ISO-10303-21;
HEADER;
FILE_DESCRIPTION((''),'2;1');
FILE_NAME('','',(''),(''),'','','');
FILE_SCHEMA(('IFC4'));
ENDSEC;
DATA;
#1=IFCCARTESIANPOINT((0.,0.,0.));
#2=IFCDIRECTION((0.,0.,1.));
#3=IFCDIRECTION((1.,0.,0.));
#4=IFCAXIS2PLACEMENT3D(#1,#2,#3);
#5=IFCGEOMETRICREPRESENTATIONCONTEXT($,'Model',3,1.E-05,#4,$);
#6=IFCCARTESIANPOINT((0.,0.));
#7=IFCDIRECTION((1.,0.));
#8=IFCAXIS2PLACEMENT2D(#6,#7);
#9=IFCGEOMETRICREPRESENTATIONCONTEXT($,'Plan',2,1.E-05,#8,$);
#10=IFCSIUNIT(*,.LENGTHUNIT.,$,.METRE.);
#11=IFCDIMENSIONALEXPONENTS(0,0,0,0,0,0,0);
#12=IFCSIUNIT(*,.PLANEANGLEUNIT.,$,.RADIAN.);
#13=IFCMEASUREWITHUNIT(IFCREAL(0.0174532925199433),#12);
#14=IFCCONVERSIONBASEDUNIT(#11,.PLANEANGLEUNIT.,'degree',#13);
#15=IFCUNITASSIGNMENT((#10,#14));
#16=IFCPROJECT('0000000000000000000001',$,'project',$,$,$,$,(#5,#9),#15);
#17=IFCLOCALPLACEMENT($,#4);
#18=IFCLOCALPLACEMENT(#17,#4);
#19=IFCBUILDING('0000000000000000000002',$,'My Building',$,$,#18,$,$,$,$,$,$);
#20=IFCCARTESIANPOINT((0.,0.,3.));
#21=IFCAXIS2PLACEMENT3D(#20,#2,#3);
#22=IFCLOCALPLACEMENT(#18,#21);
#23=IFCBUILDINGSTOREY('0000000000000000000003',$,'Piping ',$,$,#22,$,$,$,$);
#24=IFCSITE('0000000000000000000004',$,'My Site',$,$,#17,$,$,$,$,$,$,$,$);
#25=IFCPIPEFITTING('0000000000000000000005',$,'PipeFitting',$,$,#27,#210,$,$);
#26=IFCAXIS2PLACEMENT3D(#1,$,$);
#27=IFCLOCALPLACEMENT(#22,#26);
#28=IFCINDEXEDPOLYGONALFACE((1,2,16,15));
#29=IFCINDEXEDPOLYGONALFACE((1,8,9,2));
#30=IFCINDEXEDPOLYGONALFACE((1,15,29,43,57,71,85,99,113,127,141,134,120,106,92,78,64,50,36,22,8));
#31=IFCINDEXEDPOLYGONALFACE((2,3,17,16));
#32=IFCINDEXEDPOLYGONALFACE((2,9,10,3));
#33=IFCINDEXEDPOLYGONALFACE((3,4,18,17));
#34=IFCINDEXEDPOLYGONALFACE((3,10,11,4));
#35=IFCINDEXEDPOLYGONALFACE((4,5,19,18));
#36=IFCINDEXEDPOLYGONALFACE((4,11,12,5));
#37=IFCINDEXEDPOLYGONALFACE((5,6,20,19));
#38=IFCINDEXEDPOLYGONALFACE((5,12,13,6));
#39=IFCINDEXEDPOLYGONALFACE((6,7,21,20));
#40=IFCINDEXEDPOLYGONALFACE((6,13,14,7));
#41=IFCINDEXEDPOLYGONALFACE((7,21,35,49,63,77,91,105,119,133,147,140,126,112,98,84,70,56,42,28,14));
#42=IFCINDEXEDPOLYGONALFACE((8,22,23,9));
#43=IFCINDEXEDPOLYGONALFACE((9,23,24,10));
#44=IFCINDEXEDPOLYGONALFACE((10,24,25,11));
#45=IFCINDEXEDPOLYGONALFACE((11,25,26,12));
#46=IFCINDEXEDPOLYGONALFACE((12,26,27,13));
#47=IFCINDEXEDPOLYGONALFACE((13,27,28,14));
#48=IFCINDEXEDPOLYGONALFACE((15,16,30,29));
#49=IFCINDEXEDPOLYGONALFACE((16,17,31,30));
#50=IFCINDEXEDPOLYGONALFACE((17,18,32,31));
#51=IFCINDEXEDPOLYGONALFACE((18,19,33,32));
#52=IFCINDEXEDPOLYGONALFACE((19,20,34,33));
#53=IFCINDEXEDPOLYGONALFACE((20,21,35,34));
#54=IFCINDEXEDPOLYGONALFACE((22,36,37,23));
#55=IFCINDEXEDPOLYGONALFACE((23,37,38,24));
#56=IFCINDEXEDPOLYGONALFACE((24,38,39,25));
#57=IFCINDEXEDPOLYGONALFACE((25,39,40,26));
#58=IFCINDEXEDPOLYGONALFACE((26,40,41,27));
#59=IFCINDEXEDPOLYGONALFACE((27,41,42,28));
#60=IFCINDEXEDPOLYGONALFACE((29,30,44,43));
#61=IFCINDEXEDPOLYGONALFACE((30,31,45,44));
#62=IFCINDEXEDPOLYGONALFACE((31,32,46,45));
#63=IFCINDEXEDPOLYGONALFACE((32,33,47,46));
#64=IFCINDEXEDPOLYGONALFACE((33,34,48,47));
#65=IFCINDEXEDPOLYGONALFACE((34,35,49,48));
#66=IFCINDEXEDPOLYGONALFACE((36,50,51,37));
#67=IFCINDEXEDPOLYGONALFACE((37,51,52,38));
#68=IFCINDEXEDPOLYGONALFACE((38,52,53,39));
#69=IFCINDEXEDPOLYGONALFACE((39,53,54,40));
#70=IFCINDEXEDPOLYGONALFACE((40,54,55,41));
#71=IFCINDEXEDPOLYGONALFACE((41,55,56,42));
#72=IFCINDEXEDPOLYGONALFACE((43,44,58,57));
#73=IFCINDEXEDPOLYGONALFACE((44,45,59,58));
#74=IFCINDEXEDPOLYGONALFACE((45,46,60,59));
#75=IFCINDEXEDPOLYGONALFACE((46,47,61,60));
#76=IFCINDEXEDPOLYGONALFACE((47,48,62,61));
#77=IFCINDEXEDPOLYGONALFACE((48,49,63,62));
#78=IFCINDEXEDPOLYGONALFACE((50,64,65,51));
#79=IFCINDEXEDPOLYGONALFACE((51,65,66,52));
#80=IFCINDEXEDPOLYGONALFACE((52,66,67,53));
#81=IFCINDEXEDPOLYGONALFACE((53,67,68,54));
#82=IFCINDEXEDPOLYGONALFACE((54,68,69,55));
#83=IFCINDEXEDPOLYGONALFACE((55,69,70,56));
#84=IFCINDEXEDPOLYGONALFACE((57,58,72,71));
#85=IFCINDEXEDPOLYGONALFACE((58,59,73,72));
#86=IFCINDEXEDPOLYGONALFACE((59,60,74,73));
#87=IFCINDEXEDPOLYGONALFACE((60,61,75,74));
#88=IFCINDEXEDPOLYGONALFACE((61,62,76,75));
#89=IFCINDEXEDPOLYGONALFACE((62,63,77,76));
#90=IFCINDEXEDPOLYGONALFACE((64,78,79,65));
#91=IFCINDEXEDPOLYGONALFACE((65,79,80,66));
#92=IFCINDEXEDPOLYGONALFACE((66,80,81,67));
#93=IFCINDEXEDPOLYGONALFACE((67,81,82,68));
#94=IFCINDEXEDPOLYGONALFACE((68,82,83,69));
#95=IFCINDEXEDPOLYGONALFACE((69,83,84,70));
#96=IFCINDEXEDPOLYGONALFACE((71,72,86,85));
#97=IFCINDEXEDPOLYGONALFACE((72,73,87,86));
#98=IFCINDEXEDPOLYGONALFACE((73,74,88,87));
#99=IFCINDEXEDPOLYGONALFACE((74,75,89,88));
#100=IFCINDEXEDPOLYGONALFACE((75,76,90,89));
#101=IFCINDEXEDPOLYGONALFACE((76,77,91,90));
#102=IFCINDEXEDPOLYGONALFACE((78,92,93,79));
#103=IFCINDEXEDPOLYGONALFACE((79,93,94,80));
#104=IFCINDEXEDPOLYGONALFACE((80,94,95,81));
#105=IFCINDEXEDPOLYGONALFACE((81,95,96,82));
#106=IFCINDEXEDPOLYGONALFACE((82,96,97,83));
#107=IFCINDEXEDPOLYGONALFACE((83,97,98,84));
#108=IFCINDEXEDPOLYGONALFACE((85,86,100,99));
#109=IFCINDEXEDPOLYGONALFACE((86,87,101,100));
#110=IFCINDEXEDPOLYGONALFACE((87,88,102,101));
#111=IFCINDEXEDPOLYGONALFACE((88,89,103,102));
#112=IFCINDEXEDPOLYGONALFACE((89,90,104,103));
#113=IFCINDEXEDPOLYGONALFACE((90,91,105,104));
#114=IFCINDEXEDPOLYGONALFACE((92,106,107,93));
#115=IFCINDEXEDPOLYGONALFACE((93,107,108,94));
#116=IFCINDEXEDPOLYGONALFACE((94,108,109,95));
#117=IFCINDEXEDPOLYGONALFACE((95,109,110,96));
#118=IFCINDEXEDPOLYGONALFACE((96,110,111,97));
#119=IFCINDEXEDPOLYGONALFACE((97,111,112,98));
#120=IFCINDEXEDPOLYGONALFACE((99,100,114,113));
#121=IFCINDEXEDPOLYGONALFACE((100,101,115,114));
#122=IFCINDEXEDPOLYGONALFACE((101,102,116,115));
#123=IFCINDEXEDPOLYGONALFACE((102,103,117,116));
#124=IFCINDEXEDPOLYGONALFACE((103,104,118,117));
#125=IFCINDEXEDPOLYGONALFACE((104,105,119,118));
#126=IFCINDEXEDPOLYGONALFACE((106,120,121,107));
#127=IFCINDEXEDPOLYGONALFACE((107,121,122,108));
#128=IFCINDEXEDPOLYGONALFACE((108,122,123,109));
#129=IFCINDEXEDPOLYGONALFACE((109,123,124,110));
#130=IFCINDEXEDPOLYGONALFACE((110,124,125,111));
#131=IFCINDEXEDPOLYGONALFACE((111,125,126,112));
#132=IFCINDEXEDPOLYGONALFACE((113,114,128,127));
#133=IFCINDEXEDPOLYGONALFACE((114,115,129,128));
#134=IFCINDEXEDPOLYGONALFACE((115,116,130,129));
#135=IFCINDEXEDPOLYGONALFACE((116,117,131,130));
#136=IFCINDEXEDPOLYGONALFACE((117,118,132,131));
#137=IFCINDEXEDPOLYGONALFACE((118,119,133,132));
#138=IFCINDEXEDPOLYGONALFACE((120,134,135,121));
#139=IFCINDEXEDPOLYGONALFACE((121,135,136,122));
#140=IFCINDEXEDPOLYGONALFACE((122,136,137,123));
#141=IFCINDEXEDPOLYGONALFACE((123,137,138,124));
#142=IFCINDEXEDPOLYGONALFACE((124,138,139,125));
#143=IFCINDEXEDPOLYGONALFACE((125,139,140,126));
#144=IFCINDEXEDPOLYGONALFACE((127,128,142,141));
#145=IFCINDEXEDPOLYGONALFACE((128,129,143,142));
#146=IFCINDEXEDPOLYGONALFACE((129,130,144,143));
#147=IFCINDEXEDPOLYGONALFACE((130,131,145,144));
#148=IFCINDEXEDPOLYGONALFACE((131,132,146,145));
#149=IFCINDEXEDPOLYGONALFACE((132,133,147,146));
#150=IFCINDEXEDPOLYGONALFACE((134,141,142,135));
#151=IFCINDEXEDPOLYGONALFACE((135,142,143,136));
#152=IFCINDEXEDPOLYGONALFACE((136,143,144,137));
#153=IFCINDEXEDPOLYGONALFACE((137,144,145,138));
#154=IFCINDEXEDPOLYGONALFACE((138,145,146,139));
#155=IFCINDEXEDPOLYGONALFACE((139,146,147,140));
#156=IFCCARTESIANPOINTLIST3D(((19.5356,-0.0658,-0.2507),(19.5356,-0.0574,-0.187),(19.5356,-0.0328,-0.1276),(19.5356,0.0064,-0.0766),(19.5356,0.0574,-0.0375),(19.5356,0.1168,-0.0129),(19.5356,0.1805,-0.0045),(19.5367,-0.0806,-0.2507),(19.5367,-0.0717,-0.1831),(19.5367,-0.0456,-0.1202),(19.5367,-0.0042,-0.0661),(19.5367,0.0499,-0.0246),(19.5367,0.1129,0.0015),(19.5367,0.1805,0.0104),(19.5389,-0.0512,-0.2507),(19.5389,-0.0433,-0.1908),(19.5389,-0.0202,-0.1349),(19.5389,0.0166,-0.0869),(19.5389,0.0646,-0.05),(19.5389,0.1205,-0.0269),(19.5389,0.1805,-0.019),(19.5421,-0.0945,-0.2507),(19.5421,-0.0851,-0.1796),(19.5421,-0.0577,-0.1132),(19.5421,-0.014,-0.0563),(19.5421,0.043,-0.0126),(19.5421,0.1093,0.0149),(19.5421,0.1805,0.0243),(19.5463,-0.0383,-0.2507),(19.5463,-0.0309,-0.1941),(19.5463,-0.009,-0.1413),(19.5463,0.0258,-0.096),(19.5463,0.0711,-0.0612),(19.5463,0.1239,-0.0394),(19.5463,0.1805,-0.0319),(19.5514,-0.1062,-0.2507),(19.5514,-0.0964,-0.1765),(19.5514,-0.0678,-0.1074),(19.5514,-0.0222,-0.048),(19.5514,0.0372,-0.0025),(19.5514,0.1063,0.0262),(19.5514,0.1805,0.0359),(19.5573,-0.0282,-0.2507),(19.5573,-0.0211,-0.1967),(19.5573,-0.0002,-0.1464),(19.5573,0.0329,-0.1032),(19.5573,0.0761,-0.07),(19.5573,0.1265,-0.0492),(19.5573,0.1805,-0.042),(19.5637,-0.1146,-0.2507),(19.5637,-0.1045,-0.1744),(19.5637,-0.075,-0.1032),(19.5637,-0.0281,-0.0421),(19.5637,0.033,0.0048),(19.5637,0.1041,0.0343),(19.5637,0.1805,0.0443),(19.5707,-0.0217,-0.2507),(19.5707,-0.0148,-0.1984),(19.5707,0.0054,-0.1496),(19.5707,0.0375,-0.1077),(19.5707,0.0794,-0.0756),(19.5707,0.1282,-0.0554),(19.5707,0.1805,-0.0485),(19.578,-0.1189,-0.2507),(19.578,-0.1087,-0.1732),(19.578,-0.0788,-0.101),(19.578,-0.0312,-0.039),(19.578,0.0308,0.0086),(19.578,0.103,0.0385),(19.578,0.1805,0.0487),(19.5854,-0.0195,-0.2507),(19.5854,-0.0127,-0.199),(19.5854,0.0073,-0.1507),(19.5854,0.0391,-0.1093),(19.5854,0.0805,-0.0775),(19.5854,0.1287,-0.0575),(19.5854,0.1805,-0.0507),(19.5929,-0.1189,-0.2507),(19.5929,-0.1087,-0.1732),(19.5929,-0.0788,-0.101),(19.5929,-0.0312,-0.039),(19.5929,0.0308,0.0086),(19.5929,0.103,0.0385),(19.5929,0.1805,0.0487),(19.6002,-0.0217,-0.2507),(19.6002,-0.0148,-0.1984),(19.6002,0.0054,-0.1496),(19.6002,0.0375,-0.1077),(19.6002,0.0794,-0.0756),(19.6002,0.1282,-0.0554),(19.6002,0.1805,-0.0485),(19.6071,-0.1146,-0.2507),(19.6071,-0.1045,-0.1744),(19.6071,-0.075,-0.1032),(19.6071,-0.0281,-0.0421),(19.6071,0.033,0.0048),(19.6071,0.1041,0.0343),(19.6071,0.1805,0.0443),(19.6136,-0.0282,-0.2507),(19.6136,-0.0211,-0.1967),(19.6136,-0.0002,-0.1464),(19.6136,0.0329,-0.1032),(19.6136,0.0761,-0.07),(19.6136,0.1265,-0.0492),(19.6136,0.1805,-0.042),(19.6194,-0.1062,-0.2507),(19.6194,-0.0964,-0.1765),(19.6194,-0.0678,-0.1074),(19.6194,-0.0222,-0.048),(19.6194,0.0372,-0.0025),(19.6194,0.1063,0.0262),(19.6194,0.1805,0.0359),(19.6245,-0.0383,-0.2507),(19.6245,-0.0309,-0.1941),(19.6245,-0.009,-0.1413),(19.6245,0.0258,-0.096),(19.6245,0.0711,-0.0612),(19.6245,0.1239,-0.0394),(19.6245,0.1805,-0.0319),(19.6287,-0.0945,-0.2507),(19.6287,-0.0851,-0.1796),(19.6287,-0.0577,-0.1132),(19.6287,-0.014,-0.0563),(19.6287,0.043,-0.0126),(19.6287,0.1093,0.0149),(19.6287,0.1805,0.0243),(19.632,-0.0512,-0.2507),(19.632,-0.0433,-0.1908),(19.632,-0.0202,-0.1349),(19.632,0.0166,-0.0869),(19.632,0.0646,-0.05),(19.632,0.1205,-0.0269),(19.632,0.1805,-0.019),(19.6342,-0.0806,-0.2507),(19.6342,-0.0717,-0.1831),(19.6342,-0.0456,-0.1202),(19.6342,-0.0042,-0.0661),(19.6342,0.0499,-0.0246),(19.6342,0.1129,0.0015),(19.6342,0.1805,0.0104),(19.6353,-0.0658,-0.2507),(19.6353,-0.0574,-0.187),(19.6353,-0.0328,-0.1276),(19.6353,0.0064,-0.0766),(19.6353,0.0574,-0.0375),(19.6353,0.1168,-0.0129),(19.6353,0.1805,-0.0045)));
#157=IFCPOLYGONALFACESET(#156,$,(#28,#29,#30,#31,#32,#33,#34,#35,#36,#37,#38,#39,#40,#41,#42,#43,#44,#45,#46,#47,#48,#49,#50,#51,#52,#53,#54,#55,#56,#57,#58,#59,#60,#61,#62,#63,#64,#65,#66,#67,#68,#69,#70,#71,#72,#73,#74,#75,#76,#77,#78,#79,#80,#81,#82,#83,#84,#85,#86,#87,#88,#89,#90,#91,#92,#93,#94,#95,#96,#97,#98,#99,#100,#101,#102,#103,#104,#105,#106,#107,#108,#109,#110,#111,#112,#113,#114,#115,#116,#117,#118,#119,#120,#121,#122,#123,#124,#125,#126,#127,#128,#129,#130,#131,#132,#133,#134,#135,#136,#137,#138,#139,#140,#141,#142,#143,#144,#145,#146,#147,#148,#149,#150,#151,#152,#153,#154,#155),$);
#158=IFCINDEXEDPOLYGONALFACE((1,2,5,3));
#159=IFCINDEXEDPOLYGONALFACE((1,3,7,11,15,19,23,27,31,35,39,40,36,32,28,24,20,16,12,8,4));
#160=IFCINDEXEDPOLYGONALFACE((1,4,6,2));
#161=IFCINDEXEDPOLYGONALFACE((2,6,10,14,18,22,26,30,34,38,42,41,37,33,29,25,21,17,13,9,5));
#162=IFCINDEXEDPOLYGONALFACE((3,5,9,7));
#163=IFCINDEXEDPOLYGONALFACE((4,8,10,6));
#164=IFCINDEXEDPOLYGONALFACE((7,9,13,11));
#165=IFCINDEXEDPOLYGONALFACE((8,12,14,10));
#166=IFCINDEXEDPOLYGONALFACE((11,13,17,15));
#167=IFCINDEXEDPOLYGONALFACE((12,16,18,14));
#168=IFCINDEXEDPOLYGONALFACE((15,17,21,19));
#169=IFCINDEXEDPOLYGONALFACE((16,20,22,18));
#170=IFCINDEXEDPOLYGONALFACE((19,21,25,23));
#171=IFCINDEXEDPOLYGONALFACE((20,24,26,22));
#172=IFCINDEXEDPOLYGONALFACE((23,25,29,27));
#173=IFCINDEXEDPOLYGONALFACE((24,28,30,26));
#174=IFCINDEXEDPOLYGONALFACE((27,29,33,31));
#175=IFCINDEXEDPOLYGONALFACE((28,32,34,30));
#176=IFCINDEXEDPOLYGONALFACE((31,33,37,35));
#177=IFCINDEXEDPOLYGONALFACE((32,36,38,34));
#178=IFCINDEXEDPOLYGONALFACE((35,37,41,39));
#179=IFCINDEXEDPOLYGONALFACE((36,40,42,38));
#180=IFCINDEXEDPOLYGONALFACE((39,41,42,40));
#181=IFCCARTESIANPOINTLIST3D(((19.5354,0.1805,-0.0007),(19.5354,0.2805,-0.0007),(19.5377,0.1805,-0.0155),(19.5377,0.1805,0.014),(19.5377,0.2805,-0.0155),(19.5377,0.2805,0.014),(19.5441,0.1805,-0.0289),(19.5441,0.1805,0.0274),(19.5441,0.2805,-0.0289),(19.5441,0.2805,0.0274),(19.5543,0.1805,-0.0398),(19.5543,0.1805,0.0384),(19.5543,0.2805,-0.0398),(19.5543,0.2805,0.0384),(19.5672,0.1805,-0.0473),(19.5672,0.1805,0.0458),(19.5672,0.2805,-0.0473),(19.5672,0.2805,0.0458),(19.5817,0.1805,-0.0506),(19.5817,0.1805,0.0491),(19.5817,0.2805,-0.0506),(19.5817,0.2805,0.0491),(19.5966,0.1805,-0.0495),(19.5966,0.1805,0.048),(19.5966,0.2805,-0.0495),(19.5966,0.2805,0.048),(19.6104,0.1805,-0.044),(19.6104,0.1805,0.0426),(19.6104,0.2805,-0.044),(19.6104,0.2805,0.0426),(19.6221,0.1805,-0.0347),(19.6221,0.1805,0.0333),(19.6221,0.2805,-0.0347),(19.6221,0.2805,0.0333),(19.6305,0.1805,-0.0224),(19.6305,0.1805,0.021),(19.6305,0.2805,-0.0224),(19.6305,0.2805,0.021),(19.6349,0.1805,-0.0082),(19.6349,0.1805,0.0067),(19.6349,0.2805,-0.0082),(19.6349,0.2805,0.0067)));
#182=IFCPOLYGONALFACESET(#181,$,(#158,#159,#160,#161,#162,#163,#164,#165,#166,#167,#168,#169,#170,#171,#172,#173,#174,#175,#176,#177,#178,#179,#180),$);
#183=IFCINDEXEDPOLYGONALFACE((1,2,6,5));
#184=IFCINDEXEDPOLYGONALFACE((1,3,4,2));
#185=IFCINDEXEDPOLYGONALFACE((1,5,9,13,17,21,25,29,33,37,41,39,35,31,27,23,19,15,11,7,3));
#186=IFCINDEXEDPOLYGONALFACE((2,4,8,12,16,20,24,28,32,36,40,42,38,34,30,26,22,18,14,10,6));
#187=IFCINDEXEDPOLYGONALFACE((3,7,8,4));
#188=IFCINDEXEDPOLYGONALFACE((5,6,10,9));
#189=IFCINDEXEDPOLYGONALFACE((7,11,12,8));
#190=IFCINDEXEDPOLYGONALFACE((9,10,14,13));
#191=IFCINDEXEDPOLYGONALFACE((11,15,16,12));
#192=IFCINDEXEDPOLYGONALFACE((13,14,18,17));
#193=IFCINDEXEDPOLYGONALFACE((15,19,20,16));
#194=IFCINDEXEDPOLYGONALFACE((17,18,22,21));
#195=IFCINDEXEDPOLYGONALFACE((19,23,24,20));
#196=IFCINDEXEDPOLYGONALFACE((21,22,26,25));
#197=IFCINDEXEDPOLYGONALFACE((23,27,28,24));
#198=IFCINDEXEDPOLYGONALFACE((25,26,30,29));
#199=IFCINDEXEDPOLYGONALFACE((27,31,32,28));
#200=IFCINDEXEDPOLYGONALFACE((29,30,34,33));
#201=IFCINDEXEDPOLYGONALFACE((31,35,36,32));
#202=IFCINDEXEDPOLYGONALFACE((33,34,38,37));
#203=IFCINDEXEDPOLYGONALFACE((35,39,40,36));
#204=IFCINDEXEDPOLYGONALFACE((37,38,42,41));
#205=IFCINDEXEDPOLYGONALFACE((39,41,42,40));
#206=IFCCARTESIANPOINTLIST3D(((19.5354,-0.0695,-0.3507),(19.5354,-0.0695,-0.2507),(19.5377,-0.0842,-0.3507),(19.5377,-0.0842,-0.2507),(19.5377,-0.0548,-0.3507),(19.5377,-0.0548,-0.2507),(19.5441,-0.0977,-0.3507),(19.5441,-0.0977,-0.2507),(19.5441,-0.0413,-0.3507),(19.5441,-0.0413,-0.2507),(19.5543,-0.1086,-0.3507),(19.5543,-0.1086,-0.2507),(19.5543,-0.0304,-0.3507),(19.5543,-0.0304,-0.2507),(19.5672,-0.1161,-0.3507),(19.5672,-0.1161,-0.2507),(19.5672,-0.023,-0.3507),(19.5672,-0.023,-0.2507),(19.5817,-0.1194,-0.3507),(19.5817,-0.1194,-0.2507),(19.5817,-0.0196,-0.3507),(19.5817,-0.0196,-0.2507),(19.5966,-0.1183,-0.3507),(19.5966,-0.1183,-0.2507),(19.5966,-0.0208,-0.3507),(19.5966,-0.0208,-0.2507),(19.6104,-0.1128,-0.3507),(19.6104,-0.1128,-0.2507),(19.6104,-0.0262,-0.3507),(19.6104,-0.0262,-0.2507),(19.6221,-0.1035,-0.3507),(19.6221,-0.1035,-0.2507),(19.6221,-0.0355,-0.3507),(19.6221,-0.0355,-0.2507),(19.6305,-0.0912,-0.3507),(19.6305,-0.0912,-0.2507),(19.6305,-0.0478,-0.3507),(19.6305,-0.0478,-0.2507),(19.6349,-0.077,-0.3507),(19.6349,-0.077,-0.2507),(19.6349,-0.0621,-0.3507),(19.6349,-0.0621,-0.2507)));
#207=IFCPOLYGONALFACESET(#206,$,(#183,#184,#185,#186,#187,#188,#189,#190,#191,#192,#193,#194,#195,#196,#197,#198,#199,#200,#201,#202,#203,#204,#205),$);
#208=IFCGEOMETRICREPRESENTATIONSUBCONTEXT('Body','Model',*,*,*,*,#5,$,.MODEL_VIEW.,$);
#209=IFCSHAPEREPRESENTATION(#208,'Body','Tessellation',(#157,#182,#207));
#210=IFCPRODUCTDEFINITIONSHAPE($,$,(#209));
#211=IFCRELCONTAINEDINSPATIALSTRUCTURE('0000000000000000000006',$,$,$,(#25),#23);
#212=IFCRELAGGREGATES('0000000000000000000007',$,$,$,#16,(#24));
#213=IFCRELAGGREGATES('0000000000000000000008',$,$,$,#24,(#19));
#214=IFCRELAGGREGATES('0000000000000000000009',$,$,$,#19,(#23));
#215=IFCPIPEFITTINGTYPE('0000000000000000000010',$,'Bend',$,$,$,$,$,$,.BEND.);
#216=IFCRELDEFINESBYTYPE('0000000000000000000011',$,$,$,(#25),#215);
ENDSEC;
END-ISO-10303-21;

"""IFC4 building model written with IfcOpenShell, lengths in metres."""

from ifc_helpers import new_model, entity, si_unit, converted_unit, frame, origin_with_axes, origin_2d_with_axis, place, context, subcontext, project, spatial, circle, extrude, source, transform, mapped, type_object, type_shapes, element, save


model = new_model("IFC4")

# Units and contexts
model_context = context("Model", 3, precision=1e-05, world=origin_with_axes())
plan_context = context("Plan", 2, precision=1e-05, world=origin_2d_with_axis())
body_context = subcontext(model_context, "Body", "Model", "MODEL_VIEW")
ifc_project = project(units=[si_unit("LENGTHUNIT", "METRE"), converted_unit("PLANEANGLEUNIT", "degree", entity("IfcReal", 0.0174532925199433), si_unit("PLANEANGLEUNIT", "RADIAN"), dimensions=[0, 0, 0, 0, 0, 0, 0])], contexts=[model_context, plan_context])

# Site, building, storey
site_placement = place(None, origin_with_axes())
site = spatial("IfcSite", under=ifc_project, at=site_placement, Name="My Site")
building_placement = place(site_placement, origin_with_axes())
building = spatial("IfcBuilding", under=site, at=building_placement, Name="My Building")
storey_placement = place(building_placement, frame((0.0, 0.0, 3.0), z_axis=(0.0, 0.0, 1.0), x_axis=(1.0, 0.0, 0.0)))
storey = spatial("IfcBuildingStorey", under=building, at=storey_placement, Name="Piping ")

# Pipe fitting
pipe_fitting_type = type_object("IfcPipeFittingType", Name="Bend", PredefinedType="BEND")
shared_shape = source(origin_with_axes(), body_context, "Body", "SolidModel", [
    entity("IfcSweptDiskSolid", entity("IfcIndexedPolyCurve", entity("IfcCartesianPointList3D", [[0.0, 0.0, -0.1], [0.0, -0.0732, -0.2768], [0.0, -0.25, -0.35]]), [entity("IfcArcIndex", [1, 2, 3])]), 0.05),
    extrude(circle(Radius=0.05), origin_with_axes(), (0.0, 0.0, -1.0), 0.1),
    extrude(circle(Radius=0.05), frame((0.0, -0.25, -0.35), z_axis=(0.0, -1.0, 0.0), x_axis=(1.0, 0.0, 0.0)), (0.0, 0.0, 1.0), 0.1),
])
type_shapes(pipe_fitting_type, [shared_shape])
for number, where, z_axis, x_axis, name in (
    (1, (19.5854, 0.2805, -0.0007), (0.0, 1.0, 0.0), (-1.0, 0.0, 0.0), "PipeFitting"),
):
    element("IfcPipeFitting", number, at=place(storey_placement, frame(where, z_axis=z_axis, x_axis=x_axis)), inside=storey, type_object=pipe_fitting_type, Name=name, context=body_context, shape_type="MappedRepresentation", body=[
        mapped(shared_shape, transform((0.0, 0.0, 0.0), x_axis=(1.0, 0.0, 0.0), y_axis=(0.0, 1.0, 0.0), z_axis=(0.0, 0.0, 1.0), scale=1.0)),
    ])

save(model, "model.ifc")
